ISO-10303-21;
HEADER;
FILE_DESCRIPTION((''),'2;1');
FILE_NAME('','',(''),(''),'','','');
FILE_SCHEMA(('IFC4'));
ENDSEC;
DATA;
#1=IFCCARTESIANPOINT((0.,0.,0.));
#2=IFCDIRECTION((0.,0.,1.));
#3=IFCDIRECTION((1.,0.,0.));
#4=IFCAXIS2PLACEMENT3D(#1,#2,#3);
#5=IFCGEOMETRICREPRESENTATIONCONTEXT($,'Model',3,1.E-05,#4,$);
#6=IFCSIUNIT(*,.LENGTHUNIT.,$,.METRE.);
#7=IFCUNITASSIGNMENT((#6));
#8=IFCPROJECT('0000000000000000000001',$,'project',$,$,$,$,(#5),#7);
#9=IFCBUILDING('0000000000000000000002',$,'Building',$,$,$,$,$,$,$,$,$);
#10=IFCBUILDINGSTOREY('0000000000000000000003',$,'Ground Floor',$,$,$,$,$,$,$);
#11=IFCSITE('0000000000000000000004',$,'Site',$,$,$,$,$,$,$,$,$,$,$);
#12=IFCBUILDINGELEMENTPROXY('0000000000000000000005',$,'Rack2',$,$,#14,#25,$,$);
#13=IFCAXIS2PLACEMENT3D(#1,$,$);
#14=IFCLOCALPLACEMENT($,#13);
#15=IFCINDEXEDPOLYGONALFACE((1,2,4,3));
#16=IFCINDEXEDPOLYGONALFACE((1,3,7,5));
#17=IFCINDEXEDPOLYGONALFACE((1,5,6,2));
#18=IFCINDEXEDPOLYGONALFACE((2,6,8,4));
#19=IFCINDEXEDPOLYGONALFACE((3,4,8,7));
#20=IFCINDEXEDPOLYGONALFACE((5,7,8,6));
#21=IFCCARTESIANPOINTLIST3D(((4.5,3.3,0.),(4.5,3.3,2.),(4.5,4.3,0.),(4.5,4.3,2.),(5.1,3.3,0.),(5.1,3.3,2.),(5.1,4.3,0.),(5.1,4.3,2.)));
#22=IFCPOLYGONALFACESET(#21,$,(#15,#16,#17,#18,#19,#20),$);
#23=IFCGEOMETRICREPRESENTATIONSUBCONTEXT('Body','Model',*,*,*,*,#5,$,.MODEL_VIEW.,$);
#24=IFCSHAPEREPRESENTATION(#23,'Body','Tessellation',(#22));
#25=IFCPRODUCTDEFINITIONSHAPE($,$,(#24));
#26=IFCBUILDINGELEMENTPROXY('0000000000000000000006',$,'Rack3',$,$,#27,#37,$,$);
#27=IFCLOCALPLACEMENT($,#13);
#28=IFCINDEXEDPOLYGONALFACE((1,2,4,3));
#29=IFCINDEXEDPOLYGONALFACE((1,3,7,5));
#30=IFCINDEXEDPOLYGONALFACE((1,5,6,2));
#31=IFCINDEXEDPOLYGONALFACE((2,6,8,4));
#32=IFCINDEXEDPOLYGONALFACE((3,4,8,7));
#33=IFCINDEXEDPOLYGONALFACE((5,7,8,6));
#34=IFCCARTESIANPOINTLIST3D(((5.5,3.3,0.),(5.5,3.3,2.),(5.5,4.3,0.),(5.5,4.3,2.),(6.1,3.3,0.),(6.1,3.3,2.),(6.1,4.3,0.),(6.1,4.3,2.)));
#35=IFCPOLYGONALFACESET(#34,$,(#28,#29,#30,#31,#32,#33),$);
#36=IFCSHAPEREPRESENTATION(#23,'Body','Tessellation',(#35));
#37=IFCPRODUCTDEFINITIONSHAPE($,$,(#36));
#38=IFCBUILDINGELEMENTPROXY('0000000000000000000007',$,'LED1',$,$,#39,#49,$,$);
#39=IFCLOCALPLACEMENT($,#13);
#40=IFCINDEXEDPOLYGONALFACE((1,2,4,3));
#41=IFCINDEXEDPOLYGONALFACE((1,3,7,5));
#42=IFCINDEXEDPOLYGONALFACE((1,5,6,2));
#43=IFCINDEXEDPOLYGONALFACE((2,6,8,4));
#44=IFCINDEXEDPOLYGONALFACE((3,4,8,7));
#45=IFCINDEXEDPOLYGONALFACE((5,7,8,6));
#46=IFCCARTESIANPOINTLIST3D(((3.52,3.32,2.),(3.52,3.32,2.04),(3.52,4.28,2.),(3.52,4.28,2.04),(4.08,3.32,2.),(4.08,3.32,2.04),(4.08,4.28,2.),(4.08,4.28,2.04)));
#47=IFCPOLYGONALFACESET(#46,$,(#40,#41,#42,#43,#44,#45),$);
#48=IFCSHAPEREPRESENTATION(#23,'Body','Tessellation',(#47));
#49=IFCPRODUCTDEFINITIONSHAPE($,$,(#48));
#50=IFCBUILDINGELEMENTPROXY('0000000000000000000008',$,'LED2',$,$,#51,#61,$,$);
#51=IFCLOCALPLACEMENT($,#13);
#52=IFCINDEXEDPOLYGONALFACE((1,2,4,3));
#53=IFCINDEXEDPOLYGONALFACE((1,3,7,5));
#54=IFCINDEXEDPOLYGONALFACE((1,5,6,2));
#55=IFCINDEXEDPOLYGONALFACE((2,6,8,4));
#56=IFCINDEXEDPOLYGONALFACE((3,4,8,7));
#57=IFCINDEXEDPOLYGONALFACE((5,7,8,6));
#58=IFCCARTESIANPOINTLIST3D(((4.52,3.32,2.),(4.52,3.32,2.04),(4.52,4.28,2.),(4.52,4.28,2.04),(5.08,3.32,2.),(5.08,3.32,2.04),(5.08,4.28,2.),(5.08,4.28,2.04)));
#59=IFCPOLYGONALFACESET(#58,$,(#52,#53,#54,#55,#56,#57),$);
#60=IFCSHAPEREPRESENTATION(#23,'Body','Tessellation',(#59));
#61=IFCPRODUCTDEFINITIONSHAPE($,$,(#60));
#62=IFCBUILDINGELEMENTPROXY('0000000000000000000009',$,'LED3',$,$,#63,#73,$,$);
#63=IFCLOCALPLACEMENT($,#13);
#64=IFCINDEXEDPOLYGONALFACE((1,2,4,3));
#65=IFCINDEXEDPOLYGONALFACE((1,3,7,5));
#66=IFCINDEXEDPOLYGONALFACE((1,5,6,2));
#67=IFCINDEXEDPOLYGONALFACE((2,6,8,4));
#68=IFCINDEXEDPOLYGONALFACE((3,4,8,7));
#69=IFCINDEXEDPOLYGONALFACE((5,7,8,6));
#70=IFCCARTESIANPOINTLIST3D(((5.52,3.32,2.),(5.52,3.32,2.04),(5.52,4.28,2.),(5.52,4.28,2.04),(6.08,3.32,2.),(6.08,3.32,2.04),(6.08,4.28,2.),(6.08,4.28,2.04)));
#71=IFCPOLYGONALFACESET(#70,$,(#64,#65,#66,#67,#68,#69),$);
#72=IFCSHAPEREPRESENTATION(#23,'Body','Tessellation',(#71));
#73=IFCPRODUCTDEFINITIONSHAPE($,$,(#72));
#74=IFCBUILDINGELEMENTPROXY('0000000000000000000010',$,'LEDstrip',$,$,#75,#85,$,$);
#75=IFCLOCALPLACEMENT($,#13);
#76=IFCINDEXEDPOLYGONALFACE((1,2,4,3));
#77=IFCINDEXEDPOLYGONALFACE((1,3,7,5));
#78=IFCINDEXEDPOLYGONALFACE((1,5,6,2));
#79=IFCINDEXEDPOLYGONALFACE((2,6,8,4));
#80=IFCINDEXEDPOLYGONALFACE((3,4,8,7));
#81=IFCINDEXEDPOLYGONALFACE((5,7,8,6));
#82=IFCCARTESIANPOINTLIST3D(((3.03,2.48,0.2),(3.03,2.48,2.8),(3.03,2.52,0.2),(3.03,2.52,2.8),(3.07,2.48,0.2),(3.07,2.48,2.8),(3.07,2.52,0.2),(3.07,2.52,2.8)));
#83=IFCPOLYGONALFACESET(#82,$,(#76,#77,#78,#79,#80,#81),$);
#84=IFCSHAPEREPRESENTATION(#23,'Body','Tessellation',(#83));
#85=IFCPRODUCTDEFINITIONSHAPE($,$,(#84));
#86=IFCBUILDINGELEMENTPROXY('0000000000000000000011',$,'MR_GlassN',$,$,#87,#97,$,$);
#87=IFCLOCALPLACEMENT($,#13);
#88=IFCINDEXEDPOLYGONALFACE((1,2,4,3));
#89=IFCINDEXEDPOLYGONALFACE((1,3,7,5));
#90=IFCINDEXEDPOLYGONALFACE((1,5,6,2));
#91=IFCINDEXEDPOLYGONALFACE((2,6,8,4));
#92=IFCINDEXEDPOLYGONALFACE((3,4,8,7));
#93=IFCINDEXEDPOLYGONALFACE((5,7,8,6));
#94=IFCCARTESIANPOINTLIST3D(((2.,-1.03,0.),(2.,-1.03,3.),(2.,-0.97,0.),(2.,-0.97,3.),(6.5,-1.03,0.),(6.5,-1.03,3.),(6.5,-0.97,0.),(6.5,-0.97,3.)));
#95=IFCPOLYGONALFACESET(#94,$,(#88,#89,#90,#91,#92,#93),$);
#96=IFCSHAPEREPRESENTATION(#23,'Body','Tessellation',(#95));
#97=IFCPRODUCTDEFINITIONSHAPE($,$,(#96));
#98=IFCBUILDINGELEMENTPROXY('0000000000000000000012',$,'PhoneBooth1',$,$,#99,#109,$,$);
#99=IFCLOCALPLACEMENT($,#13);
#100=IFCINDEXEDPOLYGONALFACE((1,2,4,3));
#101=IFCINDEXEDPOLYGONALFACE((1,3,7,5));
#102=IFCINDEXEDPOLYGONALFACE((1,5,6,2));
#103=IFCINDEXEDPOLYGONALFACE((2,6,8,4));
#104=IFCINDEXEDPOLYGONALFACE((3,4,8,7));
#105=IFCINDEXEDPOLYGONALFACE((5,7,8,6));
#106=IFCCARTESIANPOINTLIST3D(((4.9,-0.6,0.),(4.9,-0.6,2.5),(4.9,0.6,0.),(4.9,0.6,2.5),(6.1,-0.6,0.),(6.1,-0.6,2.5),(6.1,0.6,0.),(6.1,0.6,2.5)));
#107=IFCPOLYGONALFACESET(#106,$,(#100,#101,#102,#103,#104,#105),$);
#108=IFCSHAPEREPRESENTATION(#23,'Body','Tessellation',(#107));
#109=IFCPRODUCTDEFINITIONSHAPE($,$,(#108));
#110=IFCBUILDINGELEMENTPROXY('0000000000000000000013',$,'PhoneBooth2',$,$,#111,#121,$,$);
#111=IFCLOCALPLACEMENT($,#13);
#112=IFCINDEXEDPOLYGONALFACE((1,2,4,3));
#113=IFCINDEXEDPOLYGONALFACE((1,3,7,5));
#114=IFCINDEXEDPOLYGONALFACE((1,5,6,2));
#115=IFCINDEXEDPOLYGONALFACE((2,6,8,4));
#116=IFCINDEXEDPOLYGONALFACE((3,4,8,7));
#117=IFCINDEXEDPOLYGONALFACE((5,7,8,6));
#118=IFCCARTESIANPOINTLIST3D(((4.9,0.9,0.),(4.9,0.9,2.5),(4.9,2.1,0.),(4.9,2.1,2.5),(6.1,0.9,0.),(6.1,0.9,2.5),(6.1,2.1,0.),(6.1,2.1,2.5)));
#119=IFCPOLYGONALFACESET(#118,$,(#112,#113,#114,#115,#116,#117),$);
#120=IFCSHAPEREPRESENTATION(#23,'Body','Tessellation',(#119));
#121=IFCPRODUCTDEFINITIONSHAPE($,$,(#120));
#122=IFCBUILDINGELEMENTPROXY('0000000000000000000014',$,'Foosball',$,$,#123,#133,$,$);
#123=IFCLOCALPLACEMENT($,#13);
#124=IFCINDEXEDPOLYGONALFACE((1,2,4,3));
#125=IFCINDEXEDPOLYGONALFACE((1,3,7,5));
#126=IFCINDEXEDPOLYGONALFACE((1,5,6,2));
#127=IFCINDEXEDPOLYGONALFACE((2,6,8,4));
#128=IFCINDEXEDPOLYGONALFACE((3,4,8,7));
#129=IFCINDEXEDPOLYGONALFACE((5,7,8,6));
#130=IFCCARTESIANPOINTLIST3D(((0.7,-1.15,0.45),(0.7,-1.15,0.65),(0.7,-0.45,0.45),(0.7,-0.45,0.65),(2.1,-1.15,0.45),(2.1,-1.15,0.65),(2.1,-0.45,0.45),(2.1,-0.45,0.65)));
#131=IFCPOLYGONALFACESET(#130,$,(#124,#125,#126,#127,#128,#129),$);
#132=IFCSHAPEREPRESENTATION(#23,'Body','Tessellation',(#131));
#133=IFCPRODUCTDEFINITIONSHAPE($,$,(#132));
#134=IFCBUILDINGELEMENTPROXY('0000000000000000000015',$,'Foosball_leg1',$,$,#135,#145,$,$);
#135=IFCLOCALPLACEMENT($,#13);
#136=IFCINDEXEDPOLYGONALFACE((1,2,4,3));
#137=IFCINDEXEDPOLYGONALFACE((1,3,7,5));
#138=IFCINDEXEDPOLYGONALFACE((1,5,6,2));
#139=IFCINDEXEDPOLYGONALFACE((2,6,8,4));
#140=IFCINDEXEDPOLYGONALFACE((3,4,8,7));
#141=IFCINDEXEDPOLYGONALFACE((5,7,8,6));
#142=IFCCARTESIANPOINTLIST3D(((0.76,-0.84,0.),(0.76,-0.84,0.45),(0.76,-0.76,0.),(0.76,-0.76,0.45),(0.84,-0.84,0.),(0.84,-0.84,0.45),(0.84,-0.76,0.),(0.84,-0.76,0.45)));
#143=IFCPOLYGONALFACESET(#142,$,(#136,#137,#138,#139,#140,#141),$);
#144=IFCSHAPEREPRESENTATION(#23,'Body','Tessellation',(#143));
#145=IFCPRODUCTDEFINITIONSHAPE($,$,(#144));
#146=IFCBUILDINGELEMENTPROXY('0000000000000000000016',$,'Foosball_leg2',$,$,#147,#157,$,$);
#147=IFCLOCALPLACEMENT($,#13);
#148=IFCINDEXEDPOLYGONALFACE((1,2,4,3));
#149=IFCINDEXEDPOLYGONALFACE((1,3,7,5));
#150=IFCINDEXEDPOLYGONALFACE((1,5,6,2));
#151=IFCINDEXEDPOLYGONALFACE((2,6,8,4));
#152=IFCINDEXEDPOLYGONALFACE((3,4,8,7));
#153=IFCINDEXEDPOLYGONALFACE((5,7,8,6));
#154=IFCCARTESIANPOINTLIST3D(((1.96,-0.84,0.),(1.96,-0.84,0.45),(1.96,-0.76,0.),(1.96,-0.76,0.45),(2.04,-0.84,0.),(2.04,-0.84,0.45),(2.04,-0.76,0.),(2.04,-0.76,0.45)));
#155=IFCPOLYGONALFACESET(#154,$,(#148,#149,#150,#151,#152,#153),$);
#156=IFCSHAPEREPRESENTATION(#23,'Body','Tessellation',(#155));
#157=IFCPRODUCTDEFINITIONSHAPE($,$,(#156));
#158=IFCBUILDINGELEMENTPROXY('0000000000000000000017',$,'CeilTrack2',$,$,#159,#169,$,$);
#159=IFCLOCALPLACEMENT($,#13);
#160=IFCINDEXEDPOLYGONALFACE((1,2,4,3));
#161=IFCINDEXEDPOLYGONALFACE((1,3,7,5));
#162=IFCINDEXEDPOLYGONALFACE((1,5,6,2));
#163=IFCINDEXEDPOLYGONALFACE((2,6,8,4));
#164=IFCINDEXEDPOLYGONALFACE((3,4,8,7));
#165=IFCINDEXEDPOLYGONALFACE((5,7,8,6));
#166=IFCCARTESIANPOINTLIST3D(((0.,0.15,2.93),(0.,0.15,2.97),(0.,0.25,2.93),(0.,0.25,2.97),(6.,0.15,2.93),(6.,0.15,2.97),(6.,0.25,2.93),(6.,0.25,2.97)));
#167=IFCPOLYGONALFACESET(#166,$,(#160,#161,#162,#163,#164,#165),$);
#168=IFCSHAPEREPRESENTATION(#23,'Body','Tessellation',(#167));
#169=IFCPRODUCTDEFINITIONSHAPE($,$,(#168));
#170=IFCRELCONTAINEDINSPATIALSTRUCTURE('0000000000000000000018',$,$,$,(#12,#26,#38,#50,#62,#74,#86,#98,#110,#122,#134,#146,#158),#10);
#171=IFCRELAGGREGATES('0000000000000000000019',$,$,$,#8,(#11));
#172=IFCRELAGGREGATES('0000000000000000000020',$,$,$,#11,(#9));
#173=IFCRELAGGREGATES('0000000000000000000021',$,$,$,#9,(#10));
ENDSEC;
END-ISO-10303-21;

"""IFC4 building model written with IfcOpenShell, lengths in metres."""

from ifc_helpers import new_model, si_unit, frame, origin_with_axes, origin_2d, place, context, subcontext, project, spatial, rectangle, extrude, element, save


model = new_model("IFC4")

# Units and contexts
model_context = context("Model", 3, precision=1e-05, world=origin_with_axes())
body_context = subcontext(model_context, "Body", "Model", "MODEL_VIEW")
ifc_project = project(units=[si_unit("LENGTHUNIT", "METRE")], contexts=[model_context])

# Site, building, storey
site = spatial("IfcSite", under=ifc_project, Name="Site")
building = spatial("IfcBuilding", under=site, Name="Building")
storey = spatial("IfcBuildingStorey", under=building, Name="Ground Floor")

# Building element proxies
for number, where, z_axis, x_axis, name in (
    (1, (4.8, 3.8, 1.0), (0.0, 0.0, 1.0), (1.0, 0.0, 0.0), "Rack2"),
    (2, (5.8, 3.8, 1.0), (0.0, 0.0, 1.0), (1.0, 0.0, 0.0), "Rack3"),
):
    element("IfcBuildingElementProxy", number, at=place(None, frame(where, z_axis=z_axis, x_axis=x_axis)), inside=storey, Name=name, context=body_context, shape_type="SweptSolid", body=[
        extrude(rectangle(XDim=0.6, YDim=1.0, at=origin_2d()), frame((0.0, 0.0, -1.0)), (0.0, 0.0, 1.0), 2.0),
    ])
for number, where, z_axis, x_axis, name in (
    (3, (3.8, 3.8, 2.02), (0.0, 0.0, 1.0), (1.0, 0.0, 0.0), "LED1"),
    (4, (4.8, 3.8, 2.02), (0.0, 0.0, 1.0), (1.0, 0.0, 0.0), "LED2"),
    (5, (5.8, 3.8, 2.02), (0.0, 0.0, 1.0), (1.0, 0.0, 0.0), "LED3"),
):
    element("IfcBuildingElementProxy", number, at=place(None, frame(where, z_axis=z_axis, x_axis=x_axis)), inside=storey, Name=name, context=body_context, shape_type="SweptSolid", body=[
        extrude(rectangle(XDim=0.56, YDim=0.96, at=origin_2d()), frame((0.0, 0.0, -0.02)), (0.0, 0.0, 1.0), 0.04),
    ])
proxy_1_placement = place(None, frame((3.05, 2.5, 1.5), z_axis=(0.0, 0.0, 1.0), x_axis=(1.0, 0.0, 0.0)))
element("IfcBuildingElementProxy", 6, at=proxy_1_placement, inside=storey, Name="LEDstrip", context=body_context, shape_type="SweptSolid", body=[
    extrude(rectangle(XDim=0.04, YDim=0.04, at=origin_2d()), frame((0.0, 0.0, -1.3)), (0.0, 0.0, 1.0), 2.6),
])
proxy_2_placement = place(None, frame((4.25, -1.0, 1.5), z_axis=(0.0, 0.0, 1.0), x_axis=(1.0, 0.0, 0.0)))
element("IfcBuildingElementProxy", 7, at=proxy_2_placement, inside=storey, Name="MR_GlassN", context=body_context, shape_type="SweptSolid", body=[
    extrude(rectangle(XDim=4.5, YDim=0.06, at=origin_2d()), frame((0.0, 0.0, -1.5)), (0.0, 0.0, 1.0), 3.0),
])
for number, where, z_axis, x_axis, name in (
    (8, (5.5, 0.0, 1.25), (0.0, 0.0, 1.0), (1.0, 0.0, 0.0), "PhoneBooth1"),
    (9, (5.5, 1.5, 1.25), (0.0, 0.0, 1.0), (1.0, 0.0, 0.0), "PhoneBooth2"),
):
    element("IfcBuildingElementProxy", number, at=place(None, frame(where, z_axis=z_axis, x_axis=x_axis)), inside=storey, Name=name, context=body_context, shape_type="SweptSolid", body=[
        extrude(rectangle(XDim=1.2, YDim=1.2, at=origin_2d()), frame((0.0, 0.0, -1.25)), (0.0, 0.0, 1.0), 2.5),
    ])
proxy_3_placement = place(None, frame((1.4, -0.8, 0.55), z_axis=(0.0, 0.0, 1.0), x_axis=(1.0, 0.0, 0.0)))
element("IfcBuildingElementProxy", 10, at=proxy_3_placement, inside=storey, Name="Foosball", context=body_context, shape_type="SweptSolid", body=[
    extrude(rectangle(XDim=1.4, YDim=0.7, at=origin_2d()), frame((0.0, 0.0, -0.1)), (0.0, 0.0, 1.0), 0.2),
])
for number, where, z_axis, x_axis, name in (
    (11, (0.8, -0.8, 0.225), (0.0, 0.0, 1.0), (1.0, 0.0, 0.0), "Foosball_leg1"),
    (12, (2.0, -0.8, 0.225), (0.0, 0.0, 1.0), (1.0, 0.0, 0.0), "Foosball_leg2"),
):
    element("IfcBuildingElementProxy", number, at=place(None, frame(where, z_axis=z_axis, x_axis=x_axis)), inside=storey, Name=name, context=body_context, shape_type="SweptSolid", body=[
        extrude(rectangle(XDim=0.08, YDim=0.08, at=origin_2d()), frame((0.0, 0.0, -0.225)), (0.0, 0.0, 1.0), 0.45),
    ])
proxy_4_placement = place(None, frame((3.0, 0.2, 2.95), z_axis=(0.0, 0.0, 1.0), x_axis=(1.0, 0.0, 0.0)))
element("IfcBuildingElementProxy", 13, at=proxy_4_placement, inside=storey, Name="CeilTrack2", context=body_context, shape_type="SweptSolid", body=[
    extrude(rectangle(XDim=6.0, YDim=0.1, at=origin_2d()), frame((0.0, 0.0, -0.02)), (0.0, 0.0, 1.0), 0.04),
])

save(model, "model.ifc")
